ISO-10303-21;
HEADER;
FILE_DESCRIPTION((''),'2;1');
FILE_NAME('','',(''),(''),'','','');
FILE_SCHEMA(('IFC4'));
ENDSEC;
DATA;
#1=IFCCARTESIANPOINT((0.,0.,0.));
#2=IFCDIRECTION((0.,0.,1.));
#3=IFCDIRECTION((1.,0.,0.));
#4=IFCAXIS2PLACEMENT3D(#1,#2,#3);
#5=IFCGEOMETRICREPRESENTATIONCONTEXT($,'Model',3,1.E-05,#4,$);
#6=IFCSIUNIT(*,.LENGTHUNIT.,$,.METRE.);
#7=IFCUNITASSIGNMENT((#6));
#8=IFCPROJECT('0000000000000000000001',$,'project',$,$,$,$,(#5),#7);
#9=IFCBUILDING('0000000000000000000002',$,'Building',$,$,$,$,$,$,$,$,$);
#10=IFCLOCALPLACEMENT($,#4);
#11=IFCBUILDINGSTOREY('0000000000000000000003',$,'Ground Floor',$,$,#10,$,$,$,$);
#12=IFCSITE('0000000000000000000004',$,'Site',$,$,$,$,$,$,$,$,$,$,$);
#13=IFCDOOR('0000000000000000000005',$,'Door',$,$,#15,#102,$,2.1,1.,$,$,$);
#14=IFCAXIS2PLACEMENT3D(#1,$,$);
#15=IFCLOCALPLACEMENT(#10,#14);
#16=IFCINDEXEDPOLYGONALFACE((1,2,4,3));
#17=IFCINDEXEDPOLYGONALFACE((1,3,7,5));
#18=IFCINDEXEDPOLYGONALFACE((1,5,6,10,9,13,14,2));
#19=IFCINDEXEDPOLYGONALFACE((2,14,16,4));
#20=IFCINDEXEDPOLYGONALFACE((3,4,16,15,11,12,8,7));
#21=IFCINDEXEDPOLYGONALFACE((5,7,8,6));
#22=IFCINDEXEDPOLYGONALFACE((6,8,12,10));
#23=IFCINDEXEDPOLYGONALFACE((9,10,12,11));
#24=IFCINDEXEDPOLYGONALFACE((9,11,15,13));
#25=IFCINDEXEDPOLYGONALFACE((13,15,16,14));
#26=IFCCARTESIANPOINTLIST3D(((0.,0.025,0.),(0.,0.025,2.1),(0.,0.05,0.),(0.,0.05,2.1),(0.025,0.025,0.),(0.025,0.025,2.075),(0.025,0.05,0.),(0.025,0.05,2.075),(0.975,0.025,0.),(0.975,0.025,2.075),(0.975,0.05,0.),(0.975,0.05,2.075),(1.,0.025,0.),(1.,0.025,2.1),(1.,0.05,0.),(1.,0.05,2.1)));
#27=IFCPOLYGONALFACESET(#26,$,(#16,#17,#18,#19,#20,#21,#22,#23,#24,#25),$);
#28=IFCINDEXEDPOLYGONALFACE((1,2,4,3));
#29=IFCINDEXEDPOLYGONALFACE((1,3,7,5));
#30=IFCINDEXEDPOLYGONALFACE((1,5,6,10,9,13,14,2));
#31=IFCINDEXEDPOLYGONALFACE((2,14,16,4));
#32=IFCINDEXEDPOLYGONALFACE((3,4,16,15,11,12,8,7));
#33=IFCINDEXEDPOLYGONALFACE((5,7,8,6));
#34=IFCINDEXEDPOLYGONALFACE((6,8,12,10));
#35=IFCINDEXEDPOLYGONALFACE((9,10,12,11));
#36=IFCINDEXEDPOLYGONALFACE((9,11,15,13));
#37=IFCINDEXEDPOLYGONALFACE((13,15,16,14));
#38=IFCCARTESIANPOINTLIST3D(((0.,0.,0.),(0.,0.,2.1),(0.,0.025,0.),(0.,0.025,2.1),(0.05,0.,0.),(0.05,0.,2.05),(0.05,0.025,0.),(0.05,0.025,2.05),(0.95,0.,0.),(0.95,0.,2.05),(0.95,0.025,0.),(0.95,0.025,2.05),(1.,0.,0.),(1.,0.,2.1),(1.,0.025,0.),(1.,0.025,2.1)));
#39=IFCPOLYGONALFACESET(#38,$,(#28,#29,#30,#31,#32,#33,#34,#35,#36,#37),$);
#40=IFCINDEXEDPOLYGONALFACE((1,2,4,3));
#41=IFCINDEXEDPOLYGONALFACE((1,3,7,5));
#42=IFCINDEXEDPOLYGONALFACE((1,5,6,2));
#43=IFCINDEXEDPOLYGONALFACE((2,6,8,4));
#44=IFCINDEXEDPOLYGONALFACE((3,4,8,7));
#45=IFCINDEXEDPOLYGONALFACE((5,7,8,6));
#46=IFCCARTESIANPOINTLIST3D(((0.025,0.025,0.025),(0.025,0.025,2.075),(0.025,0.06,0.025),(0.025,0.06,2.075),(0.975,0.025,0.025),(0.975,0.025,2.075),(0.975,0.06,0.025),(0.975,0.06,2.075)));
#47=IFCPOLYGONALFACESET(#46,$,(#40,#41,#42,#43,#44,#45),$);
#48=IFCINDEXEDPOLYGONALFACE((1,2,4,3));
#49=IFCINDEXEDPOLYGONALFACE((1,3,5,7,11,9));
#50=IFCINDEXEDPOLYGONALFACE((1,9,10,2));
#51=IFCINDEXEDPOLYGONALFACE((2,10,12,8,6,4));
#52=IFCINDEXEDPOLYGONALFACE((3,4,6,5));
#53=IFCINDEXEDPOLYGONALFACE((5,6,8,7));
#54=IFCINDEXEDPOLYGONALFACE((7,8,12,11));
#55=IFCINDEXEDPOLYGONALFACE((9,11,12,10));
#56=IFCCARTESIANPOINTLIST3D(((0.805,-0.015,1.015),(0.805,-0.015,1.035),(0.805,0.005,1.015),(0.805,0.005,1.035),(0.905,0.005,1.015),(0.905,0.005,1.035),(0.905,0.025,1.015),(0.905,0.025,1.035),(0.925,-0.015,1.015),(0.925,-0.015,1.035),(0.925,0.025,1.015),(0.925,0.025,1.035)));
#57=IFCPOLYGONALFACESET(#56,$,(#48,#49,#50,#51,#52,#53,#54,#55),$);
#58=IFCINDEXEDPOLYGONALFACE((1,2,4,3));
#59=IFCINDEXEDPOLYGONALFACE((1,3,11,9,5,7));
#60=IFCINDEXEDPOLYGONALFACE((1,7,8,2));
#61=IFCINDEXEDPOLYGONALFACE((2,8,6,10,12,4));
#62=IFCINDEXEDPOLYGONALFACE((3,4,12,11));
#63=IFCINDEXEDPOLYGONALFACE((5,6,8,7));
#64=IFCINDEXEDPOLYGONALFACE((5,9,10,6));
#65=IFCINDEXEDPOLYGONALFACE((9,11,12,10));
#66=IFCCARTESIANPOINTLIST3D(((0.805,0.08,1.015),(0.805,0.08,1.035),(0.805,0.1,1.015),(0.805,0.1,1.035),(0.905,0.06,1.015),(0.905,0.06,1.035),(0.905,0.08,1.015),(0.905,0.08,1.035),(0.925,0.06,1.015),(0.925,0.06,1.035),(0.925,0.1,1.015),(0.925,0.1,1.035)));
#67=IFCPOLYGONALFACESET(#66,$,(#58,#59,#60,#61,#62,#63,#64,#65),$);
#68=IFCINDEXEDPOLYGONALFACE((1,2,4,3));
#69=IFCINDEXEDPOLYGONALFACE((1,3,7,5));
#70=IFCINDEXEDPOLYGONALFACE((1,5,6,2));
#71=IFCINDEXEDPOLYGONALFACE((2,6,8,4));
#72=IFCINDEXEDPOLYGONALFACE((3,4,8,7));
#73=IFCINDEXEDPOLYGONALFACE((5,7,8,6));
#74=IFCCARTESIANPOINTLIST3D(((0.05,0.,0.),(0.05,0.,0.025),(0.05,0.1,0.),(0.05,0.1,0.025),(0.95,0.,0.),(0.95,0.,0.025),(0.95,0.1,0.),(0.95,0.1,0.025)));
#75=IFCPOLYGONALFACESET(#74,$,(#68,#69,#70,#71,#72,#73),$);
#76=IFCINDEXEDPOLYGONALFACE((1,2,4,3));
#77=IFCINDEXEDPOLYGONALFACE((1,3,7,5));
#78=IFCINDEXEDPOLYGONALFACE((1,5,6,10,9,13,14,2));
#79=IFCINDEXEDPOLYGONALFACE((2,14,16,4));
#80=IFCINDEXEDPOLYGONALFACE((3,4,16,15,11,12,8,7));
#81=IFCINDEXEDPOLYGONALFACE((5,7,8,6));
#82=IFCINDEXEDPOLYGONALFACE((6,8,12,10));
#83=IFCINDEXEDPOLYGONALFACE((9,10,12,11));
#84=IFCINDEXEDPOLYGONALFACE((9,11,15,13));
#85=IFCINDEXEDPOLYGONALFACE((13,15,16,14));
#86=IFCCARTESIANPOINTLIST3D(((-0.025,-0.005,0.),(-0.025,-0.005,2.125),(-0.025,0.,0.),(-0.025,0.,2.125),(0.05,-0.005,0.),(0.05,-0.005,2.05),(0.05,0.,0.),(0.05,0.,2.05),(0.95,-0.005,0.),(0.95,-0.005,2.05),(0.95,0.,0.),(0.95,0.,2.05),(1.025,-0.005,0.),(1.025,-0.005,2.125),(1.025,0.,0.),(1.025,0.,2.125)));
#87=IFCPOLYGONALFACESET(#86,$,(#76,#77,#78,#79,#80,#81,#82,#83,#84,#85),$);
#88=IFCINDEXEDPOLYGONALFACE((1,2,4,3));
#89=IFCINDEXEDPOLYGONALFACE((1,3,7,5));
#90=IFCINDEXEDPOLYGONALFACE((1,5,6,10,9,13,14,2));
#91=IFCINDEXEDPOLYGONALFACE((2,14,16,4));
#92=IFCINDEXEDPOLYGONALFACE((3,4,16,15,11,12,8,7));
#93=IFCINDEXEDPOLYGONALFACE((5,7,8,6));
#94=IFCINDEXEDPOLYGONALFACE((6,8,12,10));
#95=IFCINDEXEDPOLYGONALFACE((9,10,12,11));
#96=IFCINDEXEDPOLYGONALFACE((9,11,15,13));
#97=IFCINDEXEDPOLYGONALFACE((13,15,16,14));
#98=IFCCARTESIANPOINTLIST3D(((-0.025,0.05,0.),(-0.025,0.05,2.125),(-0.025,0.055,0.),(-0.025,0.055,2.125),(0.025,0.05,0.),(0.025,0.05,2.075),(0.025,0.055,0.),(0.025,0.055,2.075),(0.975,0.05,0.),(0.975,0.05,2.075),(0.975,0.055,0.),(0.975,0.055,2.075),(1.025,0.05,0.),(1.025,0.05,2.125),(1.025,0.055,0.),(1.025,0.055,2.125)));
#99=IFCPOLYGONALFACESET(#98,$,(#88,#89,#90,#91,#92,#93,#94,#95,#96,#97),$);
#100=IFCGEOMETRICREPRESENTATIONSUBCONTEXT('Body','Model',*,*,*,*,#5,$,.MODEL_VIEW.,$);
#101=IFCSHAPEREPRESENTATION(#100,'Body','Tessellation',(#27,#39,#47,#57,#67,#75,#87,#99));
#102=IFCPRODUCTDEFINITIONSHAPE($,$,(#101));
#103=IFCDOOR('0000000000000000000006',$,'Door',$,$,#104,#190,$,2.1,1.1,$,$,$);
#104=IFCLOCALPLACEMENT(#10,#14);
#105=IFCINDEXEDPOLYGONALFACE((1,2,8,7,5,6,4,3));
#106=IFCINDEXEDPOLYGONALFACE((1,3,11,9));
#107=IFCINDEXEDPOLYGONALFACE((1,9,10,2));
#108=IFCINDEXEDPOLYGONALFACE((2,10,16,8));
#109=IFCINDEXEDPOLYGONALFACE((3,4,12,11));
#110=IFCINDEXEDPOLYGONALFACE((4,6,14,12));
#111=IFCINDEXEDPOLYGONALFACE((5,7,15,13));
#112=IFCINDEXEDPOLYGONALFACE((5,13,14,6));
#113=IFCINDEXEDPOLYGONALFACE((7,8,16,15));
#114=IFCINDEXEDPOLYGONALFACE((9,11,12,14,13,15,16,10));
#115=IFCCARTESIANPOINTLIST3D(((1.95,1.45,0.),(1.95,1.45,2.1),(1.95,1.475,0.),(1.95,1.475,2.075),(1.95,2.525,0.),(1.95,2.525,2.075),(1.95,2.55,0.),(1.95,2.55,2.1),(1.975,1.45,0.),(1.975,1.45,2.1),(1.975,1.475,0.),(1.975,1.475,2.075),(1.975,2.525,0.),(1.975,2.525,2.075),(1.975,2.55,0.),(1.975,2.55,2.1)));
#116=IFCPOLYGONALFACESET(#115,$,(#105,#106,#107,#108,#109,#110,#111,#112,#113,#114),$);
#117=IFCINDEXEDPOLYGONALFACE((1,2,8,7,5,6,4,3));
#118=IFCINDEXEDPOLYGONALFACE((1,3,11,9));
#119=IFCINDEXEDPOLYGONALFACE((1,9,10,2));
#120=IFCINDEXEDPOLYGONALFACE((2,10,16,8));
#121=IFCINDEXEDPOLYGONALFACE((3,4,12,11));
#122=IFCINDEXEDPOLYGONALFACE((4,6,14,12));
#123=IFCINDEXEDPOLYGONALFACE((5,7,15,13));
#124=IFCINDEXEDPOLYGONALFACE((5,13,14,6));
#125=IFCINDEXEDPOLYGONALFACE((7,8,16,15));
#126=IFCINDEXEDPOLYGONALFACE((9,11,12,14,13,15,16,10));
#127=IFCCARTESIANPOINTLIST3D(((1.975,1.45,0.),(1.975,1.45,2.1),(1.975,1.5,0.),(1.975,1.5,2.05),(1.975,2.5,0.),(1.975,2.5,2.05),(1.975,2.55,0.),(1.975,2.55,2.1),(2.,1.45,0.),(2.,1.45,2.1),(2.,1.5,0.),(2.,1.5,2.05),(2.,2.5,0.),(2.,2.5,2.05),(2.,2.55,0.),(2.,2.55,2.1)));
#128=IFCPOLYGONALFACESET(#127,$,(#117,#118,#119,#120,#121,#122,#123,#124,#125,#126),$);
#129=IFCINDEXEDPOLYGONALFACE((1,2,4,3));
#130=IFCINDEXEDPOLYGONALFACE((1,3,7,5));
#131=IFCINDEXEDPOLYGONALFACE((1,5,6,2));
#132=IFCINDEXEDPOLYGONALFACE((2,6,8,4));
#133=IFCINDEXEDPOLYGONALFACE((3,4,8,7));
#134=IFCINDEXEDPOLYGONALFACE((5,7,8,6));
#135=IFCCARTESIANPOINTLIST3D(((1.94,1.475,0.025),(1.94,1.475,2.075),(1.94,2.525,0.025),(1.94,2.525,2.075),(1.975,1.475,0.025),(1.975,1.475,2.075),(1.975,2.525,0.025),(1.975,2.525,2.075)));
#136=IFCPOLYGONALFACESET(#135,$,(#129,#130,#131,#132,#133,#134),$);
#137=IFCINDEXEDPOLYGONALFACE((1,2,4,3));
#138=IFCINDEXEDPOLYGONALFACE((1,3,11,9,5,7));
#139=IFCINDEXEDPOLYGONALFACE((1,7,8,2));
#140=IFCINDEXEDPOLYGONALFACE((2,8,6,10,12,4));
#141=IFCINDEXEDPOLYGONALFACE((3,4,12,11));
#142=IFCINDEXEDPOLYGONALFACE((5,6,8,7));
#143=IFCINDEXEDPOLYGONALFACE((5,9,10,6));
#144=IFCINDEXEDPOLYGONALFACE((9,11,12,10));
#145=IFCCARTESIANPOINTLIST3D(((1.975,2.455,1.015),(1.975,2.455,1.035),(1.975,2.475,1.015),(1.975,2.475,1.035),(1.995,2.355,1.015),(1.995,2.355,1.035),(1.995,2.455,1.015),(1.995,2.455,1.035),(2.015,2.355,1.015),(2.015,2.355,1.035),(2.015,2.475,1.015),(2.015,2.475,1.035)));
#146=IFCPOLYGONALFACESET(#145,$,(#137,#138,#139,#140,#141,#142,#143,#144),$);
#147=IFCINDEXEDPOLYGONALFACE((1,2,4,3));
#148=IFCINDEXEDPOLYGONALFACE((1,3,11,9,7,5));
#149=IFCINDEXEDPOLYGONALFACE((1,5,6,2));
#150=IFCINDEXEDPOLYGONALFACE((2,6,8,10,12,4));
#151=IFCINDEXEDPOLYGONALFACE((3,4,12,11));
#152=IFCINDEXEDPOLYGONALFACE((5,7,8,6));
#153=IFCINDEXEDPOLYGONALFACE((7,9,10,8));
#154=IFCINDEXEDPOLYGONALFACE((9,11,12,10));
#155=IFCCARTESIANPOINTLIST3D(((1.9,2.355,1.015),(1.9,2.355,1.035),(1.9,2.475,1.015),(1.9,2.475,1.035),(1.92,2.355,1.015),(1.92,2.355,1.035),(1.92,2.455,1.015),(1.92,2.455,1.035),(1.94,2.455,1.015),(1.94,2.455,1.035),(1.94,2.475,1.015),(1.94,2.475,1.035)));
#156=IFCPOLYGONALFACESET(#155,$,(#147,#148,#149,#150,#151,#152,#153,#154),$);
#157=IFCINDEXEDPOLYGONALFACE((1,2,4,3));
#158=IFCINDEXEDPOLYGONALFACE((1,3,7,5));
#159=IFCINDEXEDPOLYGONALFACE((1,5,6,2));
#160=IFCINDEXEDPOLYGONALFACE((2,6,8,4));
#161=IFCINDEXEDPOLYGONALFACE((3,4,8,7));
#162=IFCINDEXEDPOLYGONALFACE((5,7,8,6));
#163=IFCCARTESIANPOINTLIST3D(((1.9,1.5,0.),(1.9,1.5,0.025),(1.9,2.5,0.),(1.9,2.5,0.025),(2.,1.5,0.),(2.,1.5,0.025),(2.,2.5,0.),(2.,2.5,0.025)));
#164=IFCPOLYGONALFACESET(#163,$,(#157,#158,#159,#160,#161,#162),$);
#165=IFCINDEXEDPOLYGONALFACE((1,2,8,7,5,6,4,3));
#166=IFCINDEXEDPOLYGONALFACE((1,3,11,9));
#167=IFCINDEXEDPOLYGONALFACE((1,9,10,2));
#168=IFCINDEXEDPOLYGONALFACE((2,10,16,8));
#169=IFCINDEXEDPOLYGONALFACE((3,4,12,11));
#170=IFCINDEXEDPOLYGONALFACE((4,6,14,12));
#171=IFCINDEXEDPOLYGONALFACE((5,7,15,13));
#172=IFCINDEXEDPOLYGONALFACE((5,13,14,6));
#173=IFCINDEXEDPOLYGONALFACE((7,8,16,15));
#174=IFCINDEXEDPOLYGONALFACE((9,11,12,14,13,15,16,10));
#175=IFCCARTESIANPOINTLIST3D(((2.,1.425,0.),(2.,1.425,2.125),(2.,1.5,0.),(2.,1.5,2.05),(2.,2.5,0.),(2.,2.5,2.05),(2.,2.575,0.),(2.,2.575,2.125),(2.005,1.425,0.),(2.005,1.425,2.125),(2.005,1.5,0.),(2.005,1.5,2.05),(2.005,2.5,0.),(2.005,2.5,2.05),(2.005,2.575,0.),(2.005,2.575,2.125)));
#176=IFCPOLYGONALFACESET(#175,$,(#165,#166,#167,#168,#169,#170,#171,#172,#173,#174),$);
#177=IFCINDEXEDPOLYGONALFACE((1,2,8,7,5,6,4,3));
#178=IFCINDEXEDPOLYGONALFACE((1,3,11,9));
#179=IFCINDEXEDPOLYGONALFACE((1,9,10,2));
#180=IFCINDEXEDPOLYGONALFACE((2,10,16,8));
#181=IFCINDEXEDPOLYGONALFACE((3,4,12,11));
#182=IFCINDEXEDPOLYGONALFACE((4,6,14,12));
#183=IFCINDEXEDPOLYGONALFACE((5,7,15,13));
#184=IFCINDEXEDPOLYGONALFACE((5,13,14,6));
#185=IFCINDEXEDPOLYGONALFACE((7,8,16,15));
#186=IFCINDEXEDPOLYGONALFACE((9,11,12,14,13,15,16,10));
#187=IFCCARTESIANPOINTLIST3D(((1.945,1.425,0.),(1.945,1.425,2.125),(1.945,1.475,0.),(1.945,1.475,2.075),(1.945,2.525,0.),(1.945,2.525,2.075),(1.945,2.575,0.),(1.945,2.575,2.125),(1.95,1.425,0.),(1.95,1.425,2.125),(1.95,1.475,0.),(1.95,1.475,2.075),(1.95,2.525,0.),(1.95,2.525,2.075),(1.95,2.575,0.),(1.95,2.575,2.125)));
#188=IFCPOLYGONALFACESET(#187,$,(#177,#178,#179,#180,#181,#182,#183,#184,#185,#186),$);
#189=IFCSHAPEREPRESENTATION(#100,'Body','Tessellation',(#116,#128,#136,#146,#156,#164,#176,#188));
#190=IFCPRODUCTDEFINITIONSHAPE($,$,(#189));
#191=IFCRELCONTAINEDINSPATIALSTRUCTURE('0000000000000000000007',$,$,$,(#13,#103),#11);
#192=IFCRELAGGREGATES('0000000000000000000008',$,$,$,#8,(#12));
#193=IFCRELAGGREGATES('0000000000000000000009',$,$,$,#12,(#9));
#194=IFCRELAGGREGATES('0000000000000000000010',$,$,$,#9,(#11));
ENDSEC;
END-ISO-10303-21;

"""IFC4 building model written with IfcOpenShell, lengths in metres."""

from ifc_helpers import new_model, si_unit, frame, origin_with_axes, place, context, subcontext, project, spatial, line, indexed_curve, outline, extrude, element, save


model = new_model("IFC4")

# Units and contexts
model_context = context("Model", 3, precision=1e-05, world=origin_with_axes())
body_context = subcontext(model_context, "Body", "Model", "MODEL_VIEW")
ifc_project = project(units=[si_unit("LENGTHUNIT", "METRE")], contexts=[model_context])

# Site, building, storey
site = spatial("IfcSite", under=ifc_project, Name="Site")
building = spatial("IfcBuilding", under=site, Name="Building")
storey_placement = place(None, origin_with_axes())
storey = spatial("IfcBuildingStorey", under=building, at=storey_placement, Name="Ground Floor")

# Doors
door_1_placement = place(storey_placement, origin_with_axes())
element("IfcDoor", 1, at=door_1_placement, inside=storey, Name="Door", OverallHeight=2.1, OverallWidth=1.0, context=body_context, shape_type="SweptSolid", body=[
    extrude(outline(indexed_curve([(0.0, 0.0), (0.0, 2.1), (1.0, 2.1), (1.0, 0.0), (0.975, 0.0), (0.975, 2.075), (0.025, 2.075), (0.025, 0.0)], segments=[line(1, 2, 3, 4, 5, 6, 7, 8, 1)])), frame((0.0, 0.025, 0.0), z_axis=(0.0, -1.0, 0.0), x_axis=(1.0, 0.0, 0.0)), (0.0, 0.0, -1.0), 0.025),
    extrude(outline(indexed_curve([(0.0, 0.0), (0.0, 2.1), (1.0, 2.1), (1.0, 0.0), (0.95, 0.0), (0.95, 2.05), (0.05, 2.05), (0.05, 0.0)], segments=[line(1, 2, 3, 4, 5, 6, 7, 8, 1)])), frame((0.0, 0.0, 0.0), z_axis=(0.0, -1.0, 0.0), x_axis=(1.0, 0.0, 0.0)), (0.0, 0.0, -1.0), 0.025),
    extrude(outline(indexed_curve([(0.0, 0.0), (0.95, 0.0), (0.95, 0.035), (0.0, 0.035)], segments=[line(1, 2, 3, 4, 1)])), frame((0.025, 0.025, 0.025), z_axis=(0.0, 0.0, 1.0), x_axis=(1.0, 0.0, 0.0)), (0.0, 0.0, 1.0), 2.05),
    extrude(outline(indexed_curve([(0.0, 0.0), (0.0, -0.04), (-0.12, -0.04), (-0.12, -0.02), (-0.02, -0.02), (-0.02, 0.0)], segments=[line(1, 2, 3, 4, 5, 6, 1)])), frame((0.925, 0.025, 1.015), z_axis=(0.0, 0.0, 1.0), x_axis=(1.0, 0.0, 0.0)), (0.0, 0.0, 1.0), 0.02),
    extrude(outline(indexed_curve([(0.0, 0.0), (0.0, 0.04), (-0.12, 0.04), (-0.12, 0.02), (-0.02, 0.02), (-0.02, 0.0)], segments=[line(1, 2, 3, 4, 5, 6, 1)])), frame((0.925, 0.06, 1.015), z_axis=(0.0, 0.0, 1.0), x_axis=(1.0, 0.0, 0.0)), (0.0, 0.0, 1.0), 0.02),
    extrude(outline(indexed_curve([(0.0, 0.0), (0.9, 0.0), (0.9, 0.1), (0.0, 0.1)], segments=[line(1, 2, 3, 4, 1)])), frame((0.05, 0.0, 0.0), z_axis=(0.0, 0.0, 1.0), x_axis=(1.0, 0.0, 0.0)), (0.0, 0.0, 1.0), 0.025),
    extrude(outline(indexed_curve([(0.0, 0.0), (0.0, 2.125), (1.05, 2.125), (1.05, 0.0), (0.975, 0.0), (0.975, 2.05), (0.075, 2.05), (0.075, 0.0)], segments=[line(1, 2, 3, 4, 5, 6, 7, 8, 1)])), frame((-0.025, -0.005, 0.0), z_axis=(0.0, -1.0, 0.0), x_axis=(1.0, 0.0, 0.0)), (0.0, 0.0, -1.0), 0.005),
    extrude(outline(indexed_curve([(0.0, 0.0), (0.0, 2.125), (1.05, 2.125), (1.05, 0.0), (1.0, 0.0), (1.0, 2.075), (0.05, 2.075), (0.05, 0.0)], segments=[line(1, 2, 3, 4, 5, 6, 7, 8, 1)])), frame((-0.025, 0.05, 0.0), z_axis=(0.0, -1.0, 0.0), x_axis=(1.0, 0.0, 0.0)), (0.0, 0.0, -1.0), 0.005),
])
door_2_placement = place(storey_placement, frame((2.0, 1.45, 0.0), z_axis=(0.0, 0.0, 1.0), x_axis=(0.0, 1.0, 0.0)))
element("IfcDoor", 2, at=door_2_placement, inside=storey, Name="Door", OverallHeight=2.1, OverallWidth=1.1, context=body_context, shape_type="SweptSolid", body=[
    extrude(outline(indexed_curve([(0.0, 0.0), (0.0, 2.1), (1.1, 2.1), (1.1, 0.0), (1.075, 0.0), (1.075, 2.075), (0.025, 2.075), (0.025, 0.0)], segments=[line(1, 2, 3, 4, 5, 6, 7, 8, 1)])), frame((0.0, 0.025, 0.0), z_axis=(0.0, -1.0, 0.0), x_axis=(1.0, 0.0, 0.0)), (0.0, 0.0, -1.0), 0.025),
    extrude(outline(indexed_curve([(0.0, 0.0), (0.0, 2.1), (1.1, 2.1), (1.1, 0.0), (1.05, 0.0), (1.05, 2.05), (0.05, 2.05), (0.05, 0.0)], segments=[line(1, 2, 3, 4, 5, 6, 7, 8, 1)])), frame((0.0, 0.0, 0.0), z_axis=(0.0, -1.0, 0.0), x_axis=(1.0, 0.0, 0.0)), (0.0, 0.0, -1.0), 0.025),
    extrude(outline(indexed_curve([(0.0, 0.0), (1.05, 0.0), (1.05, 0.035), (0.0, 0.035)], segments=[line(1, 2, 3, 4, 1)])), frame((0.025, 0.025, 0.025), z_axis=(0.0, 0.0, 1.0), x_axis=(1.0, 0.0, 0.0)), (0.0, 0.0, 1.0), 2.05),
    extrude(outline(indexed_curve([(0.0, 0.0), (0.0, -0.04), (-0.12, -0.04), (-0.12, -0.02), (-0.02, -0.02), (-0.02, 0.0)], segments=[line(1, 2, 3, 4, 5, 6, 1)])), frame((1.025, 0.025, 1.015), z_axis=(0.0, 0.0, 1.0), x_axis=(1.0, 0.0, 0.0)), (0.0, 0.0, 1.0), 0.02),
    extrude(outline(indexed_curve([(0.0, 0.0), (0.0, 0.04), (-0.12, 0.04), (-0.12, 0.02), (-0.02, 0.02), (-0.02, 0.0)], segments=[line(1, 2, 3, 4, 5, 6, 1)])), frame((1.025, 0.06, 1.015), z_axis=(0.0, 0.0, 1.0), x_axis=(1.0, 0.0, 0.0)), (0.0, 0.0, 1.0), 0.02),
    extrude(outline(indexed_curve([(0.0, 0.0), (1.0, 0.0), (1.0, 0.1), (0.0, 0.1)], segments=[line(1, 2, 3, 4, 1)])), frame((0.05, 0.0, 0.0), z_axis=(0.0, 0.0, 1.0), x_axis=(1.0, 0.0, 0.0)), (0.0, 0.0, 1.0), 0.025),
    extrude(outline(indexed_curve([(0.0, 0.0), (0.0, 2.125), (1.15, 2.125), (1.15, 0.0), (1.075, 0.0), (1.075, 2.05), (0.075, 2.05), (0.075, 0.0)], segments=[line(1, 2, 3, 4, 5, 6, 7, 8, 1)])), frame((-0.025, -0.005, 0.0), z_axis=(0.0, -1.0, 0.0), x_axis=(1.0, 0.0, 0.0)), (0.0, 0.0, -1.0), 0.005),
    extrude(outline(indexed_curve([(0.0, 0.0), (0.0, 2.125), (1.15, 2.125), (1.15, 0.0), (1.1, 0.0), (1.1, 2.075), (0.05, 2.075), (0.05, 0.0)], segments=[line(1, 2, 3, 4, 5, 6, 7, 8, 1)])), frame((-0.025, 0.05, 0.0), z_axis=(0.0, -1.0, 0.0), x_axis=(1.0, 0.0, 0.0)), (0.0, 0.0, -1.0), 0.005),
])

save(model, "model.ifc")
